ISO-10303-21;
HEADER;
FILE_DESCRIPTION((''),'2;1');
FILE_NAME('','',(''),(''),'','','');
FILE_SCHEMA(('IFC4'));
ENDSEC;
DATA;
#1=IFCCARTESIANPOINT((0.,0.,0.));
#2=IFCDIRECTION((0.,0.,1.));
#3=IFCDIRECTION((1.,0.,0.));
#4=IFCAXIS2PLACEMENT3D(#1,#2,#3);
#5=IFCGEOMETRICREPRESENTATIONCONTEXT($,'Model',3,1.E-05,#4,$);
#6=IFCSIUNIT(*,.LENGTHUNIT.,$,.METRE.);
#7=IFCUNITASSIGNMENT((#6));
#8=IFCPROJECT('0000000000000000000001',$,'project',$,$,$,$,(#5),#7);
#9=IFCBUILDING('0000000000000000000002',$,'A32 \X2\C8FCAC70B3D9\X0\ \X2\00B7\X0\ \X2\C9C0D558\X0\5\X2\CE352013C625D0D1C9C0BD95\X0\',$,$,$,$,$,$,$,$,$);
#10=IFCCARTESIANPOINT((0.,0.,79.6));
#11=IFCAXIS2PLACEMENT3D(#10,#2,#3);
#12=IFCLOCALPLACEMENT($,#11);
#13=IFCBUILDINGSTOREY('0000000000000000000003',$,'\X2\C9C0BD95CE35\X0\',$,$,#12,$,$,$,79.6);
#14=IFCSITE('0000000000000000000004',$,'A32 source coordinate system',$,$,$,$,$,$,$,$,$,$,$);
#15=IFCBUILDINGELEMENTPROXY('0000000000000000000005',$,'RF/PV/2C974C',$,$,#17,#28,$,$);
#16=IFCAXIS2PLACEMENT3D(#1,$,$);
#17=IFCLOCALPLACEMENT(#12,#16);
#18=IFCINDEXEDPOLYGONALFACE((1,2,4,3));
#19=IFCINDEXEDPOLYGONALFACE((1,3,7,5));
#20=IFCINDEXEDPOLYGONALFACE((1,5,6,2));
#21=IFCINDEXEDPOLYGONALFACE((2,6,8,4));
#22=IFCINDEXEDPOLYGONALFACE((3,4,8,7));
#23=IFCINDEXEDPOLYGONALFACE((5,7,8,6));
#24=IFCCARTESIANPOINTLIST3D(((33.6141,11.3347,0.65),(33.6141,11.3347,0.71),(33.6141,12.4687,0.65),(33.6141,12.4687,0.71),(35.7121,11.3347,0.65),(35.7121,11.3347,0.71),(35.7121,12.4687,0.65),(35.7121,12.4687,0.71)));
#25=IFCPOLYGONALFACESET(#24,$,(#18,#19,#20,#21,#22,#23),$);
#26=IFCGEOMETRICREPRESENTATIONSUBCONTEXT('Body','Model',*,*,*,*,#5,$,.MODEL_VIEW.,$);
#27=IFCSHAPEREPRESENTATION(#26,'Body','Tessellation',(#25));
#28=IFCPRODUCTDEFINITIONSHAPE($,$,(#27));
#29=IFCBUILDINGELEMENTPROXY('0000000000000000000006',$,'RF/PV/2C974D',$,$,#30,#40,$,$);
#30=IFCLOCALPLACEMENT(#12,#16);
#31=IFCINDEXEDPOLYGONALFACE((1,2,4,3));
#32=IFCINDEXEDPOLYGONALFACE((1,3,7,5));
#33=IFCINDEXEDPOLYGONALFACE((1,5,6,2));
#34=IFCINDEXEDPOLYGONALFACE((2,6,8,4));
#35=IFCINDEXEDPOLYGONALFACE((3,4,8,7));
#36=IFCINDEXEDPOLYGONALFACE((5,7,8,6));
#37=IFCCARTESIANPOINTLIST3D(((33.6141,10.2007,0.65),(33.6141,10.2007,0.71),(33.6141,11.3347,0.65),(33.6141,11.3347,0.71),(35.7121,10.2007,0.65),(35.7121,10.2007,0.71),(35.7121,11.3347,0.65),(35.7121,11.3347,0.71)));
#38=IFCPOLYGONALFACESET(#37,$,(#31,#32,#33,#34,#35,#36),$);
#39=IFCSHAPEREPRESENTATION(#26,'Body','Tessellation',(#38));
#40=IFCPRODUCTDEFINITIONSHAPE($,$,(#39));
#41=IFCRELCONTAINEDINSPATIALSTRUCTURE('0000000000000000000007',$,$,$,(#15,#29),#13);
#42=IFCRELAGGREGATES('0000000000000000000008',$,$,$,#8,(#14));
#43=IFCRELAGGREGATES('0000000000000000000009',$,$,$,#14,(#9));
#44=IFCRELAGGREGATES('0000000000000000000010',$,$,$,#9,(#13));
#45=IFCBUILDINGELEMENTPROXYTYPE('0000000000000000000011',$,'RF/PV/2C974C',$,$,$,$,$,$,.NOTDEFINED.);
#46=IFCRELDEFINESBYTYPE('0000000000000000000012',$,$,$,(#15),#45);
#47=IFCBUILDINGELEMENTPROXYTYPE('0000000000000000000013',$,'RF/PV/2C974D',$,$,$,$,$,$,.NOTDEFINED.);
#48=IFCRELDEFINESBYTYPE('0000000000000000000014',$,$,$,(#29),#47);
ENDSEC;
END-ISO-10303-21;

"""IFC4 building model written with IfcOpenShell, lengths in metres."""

from ifc_helpers import new_model, si_unit, frame, origin, origin_with_axes, place, context, subcontext, project, spatial, polyline, outline, extrude, source, transform, mapped, type_object, type_shapes, element, save


model = new_model("IFC4")

# Units and contexts
model_context = context("Model", 3, precision=1e-05, world=origin_with_axes())
body_context = subcontext(model_context, "Body", "Model", "MODEL_VIEW")
ifc_project = project(units=[si_unit("LENGTHUNIT", "METRE")], contexts=[model_context])

# Site, building, storey
site = spatial("IfcSite", under=ifc_project, Name="A32 source coordinate system")
building = spatial("IfcBuilding", under=site, Name="A32 주거동 · 지하5층–옥탑지붕")
storey_placement = place(None, frame((0.0, 0.0, 79.6), z_axis=(0.0, 0.0, 1.0), x_axis=(1.0, 0.0, 0.0)))
storey = spatial("IfcBuildingStorey", under=building, at=storey_placement, Name="지붕층", Elevation=79.6)

# Building element proxies
building_element_proxy_type_1 = type_object("IfcBuildingElementProxyType", Name="RF/PV/2C974C", PredefinedType="NOTDEFINED")
shared_shape_1 = source(origin(), body_context, "Body", "SweptSolid", [
    extrude(outline(polyline([(35.7121, 12.4687), (35.7121, 11.3347), (33.6141, 11.3347), (33.6141, 12.4687), (35.7121, 12.4687)])), frame((0.0, 0.0, 0.65)), (0.0, 0.0, 1.0), 0.06),
])
type_shapes(building_element_proxy_type_1, [shared_shape_1])
proxy_1_placement = place(storey_placement, origin_with_axes())
element("IfcBuildingElementProxy", 1, at=proxy_1_placement, inside=storey, type_object=building_element_proxy_type_1, Name="RF/PV/2C974C", context=body_context, shape_type="MappedRepresentation", body=[
    mapped(shared_shape_1, transform((0.0, 0.0, 0.0), scale=1.0)),
])
building_element_proxy_type_2 = type_object("IfcBuildingElementProxyType", Name="RF/PV/2C974D", PredefinedType="NOTDEFINED")
shared_shape_2 = source(origin(), body_context, "Body", "SweptSolid", [
    extrude(outline(polyline([(35.7121, 11.3347), (35.7121, 10.2007), (33.6141, 10.2007), (33.6141, 11.3347), (35.7121, 11.3347)])), frame((0.0, 0.0, 0.65)), (0.0, 0.0, 1.0), 0.06),
])
type_shapes(building_element_proxy_type_2, [shared_shape_2])
proxy_2_placement = place(storey_placement, origin_with_axes())
element("IfcBuildingElementProxy", 2, at=proxy_2_placement, inside=storey, type_object=building_element_proxy_type_2, Name="RF/PV/2C974D", context=body_context, shape_type="MappedRepresentation", body=[
    mapped(shared_shape_2, transform((0.0, 0.0, 0.0), scale=1.0)),
])

save(model, "model.ifc")
